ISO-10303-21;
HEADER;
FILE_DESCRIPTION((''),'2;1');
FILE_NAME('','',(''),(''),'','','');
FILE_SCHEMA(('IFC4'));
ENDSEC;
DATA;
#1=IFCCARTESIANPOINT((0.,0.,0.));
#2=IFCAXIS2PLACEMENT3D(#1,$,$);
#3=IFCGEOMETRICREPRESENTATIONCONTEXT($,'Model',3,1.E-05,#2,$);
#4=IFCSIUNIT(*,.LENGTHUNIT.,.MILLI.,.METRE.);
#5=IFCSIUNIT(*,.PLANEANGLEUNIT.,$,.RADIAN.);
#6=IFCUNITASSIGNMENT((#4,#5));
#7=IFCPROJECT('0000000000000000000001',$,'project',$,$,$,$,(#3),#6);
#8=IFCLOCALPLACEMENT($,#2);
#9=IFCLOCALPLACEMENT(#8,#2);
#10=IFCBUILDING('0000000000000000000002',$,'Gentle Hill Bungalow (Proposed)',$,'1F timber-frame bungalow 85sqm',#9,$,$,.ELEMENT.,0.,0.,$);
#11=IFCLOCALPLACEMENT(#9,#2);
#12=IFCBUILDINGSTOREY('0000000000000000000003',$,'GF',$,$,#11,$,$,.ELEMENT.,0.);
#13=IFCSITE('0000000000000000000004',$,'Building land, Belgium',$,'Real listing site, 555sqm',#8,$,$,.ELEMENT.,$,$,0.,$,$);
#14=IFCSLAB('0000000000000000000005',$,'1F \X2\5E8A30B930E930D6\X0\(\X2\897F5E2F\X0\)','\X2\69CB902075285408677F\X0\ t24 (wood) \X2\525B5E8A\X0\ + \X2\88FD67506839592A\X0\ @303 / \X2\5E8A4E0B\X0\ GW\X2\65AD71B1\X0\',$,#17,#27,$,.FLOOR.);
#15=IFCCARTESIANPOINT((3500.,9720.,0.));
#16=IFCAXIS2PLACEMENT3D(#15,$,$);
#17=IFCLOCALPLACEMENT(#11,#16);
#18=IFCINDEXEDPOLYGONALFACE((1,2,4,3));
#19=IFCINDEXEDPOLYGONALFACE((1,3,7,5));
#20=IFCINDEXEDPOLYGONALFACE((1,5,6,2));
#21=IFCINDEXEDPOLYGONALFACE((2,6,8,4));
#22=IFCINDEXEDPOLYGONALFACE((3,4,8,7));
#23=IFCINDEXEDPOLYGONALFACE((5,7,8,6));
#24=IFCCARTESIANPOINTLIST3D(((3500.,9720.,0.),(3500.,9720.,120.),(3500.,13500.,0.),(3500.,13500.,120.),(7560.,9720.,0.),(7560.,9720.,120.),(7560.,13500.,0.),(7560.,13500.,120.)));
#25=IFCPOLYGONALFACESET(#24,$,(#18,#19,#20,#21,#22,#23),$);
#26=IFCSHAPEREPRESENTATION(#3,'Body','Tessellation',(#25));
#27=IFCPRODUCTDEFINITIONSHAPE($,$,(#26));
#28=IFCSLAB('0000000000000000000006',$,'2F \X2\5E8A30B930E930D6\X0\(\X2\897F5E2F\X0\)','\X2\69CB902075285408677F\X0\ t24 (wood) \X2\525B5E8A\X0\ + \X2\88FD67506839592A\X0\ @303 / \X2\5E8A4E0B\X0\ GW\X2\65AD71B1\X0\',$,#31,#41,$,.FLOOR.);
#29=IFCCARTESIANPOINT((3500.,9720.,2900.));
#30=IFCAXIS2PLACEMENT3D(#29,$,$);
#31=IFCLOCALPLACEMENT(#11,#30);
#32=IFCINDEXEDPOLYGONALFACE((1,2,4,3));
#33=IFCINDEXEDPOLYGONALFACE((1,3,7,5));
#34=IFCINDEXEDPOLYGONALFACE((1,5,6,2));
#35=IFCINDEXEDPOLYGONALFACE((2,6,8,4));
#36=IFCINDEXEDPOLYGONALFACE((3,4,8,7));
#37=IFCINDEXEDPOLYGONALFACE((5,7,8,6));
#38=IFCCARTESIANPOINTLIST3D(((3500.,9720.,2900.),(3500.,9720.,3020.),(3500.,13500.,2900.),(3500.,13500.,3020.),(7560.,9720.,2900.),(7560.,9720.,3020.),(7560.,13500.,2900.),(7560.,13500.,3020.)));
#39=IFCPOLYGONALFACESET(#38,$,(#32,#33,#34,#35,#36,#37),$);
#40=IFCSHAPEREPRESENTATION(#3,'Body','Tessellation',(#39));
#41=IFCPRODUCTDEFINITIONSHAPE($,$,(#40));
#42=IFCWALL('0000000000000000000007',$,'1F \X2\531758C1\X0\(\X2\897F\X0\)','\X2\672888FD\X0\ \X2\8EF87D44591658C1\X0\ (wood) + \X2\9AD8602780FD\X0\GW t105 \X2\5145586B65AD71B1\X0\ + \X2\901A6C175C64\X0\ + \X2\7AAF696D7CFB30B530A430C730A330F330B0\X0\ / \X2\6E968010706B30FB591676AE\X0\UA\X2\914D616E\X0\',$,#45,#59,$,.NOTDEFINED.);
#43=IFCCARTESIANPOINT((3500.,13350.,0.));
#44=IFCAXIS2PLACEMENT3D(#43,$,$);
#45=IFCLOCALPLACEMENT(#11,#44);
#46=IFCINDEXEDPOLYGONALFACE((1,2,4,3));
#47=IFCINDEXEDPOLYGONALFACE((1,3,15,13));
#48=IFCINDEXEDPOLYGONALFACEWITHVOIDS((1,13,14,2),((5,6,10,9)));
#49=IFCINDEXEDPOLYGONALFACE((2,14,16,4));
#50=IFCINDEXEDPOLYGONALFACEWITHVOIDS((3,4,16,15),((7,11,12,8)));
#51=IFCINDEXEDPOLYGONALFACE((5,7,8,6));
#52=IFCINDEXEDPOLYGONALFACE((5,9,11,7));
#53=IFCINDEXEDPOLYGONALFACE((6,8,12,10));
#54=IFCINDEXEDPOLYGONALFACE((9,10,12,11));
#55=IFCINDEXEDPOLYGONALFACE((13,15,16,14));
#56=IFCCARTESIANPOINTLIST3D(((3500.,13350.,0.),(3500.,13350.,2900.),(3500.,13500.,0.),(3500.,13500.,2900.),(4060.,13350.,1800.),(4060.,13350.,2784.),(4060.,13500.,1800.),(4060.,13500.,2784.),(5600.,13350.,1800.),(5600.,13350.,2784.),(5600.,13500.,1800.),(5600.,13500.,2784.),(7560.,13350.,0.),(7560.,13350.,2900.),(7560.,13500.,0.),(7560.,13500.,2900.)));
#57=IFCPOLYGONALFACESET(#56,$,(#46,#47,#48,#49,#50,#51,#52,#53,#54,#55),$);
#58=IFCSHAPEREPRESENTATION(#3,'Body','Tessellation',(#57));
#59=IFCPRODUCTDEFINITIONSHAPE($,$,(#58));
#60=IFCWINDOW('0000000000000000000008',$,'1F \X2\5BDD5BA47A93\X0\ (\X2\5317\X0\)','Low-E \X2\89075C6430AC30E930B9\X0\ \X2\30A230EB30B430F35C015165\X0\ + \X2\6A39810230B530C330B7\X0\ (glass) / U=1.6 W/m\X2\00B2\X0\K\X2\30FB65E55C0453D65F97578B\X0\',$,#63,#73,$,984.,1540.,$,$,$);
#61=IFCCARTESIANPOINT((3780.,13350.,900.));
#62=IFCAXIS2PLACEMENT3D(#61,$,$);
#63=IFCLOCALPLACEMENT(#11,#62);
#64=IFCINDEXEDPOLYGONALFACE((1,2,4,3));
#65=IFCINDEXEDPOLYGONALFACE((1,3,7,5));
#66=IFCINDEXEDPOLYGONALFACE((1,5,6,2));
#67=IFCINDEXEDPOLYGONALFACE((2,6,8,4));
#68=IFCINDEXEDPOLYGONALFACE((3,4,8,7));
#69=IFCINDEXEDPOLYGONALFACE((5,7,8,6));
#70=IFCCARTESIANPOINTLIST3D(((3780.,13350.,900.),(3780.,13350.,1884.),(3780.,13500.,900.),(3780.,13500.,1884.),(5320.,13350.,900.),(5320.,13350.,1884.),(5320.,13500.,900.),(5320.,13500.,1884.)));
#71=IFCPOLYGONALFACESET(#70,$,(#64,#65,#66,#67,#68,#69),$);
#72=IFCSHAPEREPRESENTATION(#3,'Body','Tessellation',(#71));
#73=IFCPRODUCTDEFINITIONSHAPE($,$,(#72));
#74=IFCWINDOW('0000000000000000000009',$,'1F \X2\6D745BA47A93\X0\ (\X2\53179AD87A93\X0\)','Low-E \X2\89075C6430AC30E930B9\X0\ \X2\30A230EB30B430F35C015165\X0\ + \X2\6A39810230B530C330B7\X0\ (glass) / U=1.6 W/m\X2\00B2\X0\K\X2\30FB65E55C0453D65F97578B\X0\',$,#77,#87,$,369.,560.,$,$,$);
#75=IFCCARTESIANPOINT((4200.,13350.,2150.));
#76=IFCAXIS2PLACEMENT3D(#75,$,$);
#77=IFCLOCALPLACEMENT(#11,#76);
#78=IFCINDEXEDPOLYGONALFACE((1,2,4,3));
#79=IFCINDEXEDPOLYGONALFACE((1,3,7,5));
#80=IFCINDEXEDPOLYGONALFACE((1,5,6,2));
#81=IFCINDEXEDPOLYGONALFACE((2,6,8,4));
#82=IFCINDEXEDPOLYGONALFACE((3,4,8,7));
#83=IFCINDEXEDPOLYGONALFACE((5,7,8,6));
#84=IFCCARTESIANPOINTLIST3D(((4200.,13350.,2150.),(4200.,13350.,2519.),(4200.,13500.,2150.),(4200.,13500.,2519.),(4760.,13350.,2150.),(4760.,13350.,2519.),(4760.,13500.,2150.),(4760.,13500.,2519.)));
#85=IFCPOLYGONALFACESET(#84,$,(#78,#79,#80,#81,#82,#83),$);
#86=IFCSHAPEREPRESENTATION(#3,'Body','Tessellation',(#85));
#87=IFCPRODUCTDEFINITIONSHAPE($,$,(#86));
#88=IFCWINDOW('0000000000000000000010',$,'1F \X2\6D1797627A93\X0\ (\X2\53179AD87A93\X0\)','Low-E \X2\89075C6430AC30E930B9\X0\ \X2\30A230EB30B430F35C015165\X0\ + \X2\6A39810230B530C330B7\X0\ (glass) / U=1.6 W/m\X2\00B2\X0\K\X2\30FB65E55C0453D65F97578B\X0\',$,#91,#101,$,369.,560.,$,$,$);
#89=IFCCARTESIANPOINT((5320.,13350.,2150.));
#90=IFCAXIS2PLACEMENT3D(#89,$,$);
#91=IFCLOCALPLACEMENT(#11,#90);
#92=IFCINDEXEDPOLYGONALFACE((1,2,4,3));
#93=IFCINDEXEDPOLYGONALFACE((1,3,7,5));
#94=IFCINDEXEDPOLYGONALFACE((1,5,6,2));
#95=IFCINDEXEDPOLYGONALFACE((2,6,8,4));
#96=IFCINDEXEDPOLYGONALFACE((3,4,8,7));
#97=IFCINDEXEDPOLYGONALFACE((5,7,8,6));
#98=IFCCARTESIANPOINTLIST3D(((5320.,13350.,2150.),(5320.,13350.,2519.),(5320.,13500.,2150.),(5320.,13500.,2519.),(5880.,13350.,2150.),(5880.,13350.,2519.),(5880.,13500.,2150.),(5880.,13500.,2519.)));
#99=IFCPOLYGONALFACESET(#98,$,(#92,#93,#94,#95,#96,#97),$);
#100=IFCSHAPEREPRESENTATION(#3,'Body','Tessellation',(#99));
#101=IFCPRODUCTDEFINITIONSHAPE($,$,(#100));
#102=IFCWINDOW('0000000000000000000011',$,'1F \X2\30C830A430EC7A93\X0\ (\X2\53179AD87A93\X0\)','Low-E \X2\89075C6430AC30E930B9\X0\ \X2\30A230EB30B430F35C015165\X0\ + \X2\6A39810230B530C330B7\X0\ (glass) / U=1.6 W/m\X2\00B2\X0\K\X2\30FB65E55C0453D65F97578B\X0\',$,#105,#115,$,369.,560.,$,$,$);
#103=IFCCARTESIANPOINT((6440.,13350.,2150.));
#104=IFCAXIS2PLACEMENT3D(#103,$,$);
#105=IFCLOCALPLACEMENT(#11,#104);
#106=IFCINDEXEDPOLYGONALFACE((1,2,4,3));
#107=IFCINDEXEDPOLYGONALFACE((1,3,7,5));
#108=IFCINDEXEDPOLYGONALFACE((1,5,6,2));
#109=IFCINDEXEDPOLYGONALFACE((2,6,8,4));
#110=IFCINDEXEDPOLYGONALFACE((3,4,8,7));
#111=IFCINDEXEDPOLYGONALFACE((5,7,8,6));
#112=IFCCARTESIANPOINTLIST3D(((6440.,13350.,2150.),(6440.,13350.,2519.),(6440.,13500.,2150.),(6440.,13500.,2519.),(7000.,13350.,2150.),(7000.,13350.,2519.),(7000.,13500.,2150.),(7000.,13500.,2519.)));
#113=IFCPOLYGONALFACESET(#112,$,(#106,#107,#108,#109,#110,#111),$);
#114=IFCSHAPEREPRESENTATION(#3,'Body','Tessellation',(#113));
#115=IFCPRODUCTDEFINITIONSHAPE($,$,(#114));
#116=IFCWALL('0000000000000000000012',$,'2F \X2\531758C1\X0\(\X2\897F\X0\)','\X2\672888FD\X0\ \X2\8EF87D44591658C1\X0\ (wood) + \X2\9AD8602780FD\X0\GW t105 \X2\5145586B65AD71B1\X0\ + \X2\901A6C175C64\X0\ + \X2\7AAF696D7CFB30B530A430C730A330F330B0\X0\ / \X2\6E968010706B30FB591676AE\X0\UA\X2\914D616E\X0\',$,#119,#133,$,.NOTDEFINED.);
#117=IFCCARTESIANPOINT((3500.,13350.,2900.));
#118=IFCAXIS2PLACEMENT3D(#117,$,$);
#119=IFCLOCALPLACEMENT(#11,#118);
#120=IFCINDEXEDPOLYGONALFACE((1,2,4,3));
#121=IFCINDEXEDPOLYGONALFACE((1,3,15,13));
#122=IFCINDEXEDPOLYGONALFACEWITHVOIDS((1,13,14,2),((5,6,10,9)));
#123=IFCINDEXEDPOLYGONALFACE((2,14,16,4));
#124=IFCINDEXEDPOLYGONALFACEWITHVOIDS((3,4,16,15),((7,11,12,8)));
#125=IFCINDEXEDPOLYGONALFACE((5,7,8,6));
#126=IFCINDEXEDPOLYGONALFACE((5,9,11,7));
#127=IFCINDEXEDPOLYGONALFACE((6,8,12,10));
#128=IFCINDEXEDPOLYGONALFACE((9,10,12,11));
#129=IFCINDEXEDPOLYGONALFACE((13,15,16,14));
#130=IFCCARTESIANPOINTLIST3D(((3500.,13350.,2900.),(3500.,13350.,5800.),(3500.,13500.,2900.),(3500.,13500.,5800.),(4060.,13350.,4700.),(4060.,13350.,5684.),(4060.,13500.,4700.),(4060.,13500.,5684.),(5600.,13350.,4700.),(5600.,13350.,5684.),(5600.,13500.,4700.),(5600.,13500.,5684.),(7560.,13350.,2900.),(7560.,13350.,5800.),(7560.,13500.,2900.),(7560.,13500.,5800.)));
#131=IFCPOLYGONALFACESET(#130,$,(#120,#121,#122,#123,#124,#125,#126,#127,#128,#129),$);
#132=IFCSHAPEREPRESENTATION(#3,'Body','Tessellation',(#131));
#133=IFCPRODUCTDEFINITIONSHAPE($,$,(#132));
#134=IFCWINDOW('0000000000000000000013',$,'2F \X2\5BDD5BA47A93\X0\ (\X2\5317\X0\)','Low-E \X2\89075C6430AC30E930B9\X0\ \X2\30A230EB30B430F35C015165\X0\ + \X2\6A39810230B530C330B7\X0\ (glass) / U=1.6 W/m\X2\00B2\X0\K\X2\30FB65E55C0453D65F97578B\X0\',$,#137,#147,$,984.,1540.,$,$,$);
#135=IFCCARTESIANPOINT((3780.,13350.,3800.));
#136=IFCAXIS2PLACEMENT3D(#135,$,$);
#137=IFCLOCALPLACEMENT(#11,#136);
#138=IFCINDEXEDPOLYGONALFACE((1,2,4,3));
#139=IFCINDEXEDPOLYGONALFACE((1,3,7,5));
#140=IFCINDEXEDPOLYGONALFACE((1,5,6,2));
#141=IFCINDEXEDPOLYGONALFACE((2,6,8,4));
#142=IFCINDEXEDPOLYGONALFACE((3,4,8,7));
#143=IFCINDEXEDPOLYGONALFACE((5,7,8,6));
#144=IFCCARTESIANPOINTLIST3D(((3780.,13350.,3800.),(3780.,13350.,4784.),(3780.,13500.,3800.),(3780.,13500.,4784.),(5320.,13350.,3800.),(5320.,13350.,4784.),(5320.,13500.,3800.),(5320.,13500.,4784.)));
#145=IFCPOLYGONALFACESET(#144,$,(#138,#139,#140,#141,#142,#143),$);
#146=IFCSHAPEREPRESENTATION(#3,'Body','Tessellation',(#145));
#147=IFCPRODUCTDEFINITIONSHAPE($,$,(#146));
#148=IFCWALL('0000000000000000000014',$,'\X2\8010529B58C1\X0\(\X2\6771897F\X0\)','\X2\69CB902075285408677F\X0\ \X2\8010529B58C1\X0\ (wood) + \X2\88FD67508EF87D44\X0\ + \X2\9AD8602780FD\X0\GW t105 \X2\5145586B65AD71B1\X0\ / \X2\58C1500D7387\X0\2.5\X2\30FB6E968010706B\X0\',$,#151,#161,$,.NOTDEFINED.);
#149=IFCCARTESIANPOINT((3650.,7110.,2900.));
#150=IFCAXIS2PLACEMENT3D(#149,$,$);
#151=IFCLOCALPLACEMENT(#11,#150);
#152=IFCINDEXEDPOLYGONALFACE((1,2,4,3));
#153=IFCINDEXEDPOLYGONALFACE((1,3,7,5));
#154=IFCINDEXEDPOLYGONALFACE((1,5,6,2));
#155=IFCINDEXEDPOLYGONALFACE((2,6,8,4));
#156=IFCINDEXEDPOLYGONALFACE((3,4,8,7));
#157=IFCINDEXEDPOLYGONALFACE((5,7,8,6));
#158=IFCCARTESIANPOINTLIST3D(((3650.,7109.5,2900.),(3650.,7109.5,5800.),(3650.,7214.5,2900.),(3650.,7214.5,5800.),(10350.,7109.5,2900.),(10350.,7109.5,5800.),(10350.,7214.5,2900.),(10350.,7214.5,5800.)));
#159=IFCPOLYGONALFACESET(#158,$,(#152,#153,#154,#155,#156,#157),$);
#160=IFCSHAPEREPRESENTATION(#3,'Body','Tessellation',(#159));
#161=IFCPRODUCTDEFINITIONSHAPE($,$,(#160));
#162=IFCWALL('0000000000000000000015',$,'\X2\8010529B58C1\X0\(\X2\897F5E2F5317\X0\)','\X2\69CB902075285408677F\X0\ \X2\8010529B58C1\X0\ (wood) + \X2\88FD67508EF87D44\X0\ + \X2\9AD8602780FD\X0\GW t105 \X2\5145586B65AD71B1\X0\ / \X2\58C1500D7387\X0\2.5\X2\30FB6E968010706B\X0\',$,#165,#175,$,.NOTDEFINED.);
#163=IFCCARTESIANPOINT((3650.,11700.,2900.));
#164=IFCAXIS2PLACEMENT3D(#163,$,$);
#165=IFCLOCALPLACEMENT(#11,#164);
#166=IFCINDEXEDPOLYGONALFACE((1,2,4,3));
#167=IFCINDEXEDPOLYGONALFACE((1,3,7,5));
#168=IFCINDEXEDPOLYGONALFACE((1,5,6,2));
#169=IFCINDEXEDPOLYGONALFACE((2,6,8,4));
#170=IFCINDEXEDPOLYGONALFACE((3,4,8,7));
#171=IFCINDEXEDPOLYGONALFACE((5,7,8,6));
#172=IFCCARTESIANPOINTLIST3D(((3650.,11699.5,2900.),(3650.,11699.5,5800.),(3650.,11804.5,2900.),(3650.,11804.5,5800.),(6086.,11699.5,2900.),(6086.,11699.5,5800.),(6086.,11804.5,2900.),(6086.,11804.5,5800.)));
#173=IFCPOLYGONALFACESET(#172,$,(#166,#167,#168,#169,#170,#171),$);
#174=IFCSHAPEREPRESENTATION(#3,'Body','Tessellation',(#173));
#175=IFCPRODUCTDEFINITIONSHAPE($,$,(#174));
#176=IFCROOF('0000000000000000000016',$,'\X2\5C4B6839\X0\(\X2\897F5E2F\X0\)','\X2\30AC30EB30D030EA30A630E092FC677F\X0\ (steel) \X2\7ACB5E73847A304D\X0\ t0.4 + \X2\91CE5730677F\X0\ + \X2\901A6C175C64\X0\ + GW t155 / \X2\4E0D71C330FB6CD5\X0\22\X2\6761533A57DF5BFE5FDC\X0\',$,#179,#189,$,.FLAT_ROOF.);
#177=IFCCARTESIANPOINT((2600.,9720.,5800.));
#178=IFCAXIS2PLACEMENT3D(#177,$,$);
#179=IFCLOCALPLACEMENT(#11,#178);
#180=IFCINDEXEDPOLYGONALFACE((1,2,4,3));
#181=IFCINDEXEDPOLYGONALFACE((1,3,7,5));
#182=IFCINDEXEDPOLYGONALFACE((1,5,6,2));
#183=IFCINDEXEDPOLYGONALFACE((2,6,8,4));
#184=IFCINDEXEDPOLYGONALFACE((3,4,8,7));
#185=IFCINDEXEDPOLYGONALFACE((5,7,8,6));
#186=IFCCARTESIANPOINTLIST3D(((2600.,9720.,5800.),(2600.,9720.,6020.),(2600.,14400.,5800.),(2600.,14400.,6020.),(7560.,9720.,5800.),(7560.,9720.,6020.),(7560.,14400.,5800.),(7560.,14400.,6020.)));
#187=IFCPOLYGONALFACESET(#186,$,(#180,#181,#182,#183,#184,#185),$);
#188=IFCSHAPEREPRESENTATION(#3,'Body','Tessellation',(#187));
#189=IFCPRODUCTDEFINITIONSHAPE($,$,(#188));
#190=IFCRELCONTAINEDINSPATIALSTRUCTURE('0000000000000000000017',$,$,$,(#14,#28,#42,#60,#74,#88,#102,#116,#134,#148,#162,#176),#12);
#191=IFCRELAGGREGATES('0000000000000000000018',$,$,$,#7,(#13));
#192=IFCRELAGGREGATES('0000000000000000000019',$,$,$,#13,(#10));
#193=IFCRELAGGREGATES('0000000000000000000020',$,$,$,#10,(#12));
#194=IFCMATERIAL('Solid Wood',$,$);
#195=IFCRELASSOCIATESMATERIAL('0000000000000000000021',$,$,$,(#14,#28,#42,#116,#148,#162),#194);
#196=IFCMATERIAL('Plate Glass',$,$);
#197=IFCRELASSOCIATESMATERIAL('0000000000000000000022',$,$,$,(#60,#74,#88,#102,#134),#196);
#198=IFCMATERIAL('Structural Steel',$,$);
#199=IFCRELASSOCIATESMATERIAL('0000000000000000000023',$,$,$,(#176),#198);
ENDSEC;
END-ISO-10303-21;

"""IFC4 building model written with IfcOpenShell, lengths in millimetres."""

from ifc_helpers import new_model, si_unit, frame, frame_2d, origin, place, context, project, spatial, rectangle, extrude, material, element, fill, save


model = new_model("IFC4")

# Units and contexts
model_context = context("Model", 3, precision=1e-05, world=origin())
ifc_project = project(units=[si_unit("LENGTHUNIT", "METRE", prefix="MILLI"), si_unit("PLANEANGLEUNIT", "RADIAN")], contexts=[model_context])

# Site, building, storey
site_placement = place(None, origin())
site = spatial("IfcSite", under=ifc_project, at=site_placement, Name="Building land, Belgium", ObjectType="Real listing site, 555sqm", CompositionType="ELEMENT", RefElevation=0.0)
building_placement = place(site_placement, origin())
building = spatial("IfcBuilding", under=site, at=building_placement, Name="Gentle Hill Bungalow (Proposed)", ObjectType="1F timber-frame bungalow 85sqm", CompositionType="ELEMENT", ElevationOfRefHeight=0.0, ElevationOfTerrain=0.0)
storey_placement = place(building_placement, origin())
storey = spatial("IfcBuildingStorey", under=building, at=storey_placement, Name="GF", CompositionType="ELEMENT", Elevation=0.0)

# Slabs
ifc_material_1 = material(Name="Solid Wood")
slab_1_placement = place(storey_placement, frame((3500.0, 9720.0, 0.0)))
element("IfcSlab", 1, at=slab_1_placement, inside=storey, material=ifc_material_1, Name="1F 床スラブ(西帯)", Description="構造用合板 t24 (wood) 剛床 + 製材根太 @303 / 床下 GW断熱", PredefinedType="FLOOR", context=model_context, shape_type="SweptSolid", body=[
    extrude(rectangle(XDim=4060.0, YDim=3780.0, at=frame_2d((2030.0, 1890.0))), frame((3500.0, 9720.0, 0.0)), (0.0, 0.0, 1.0), 120.0),
])
slab_2_placement = place(storey_placement, frame((3500.0, 9720.0, 2900.0)))
element("IfcSlab", 2, at=slab_2_placement, inside=storey, material=ifc_material_1, Name="2F 床スラブ(西帯)", Description="構造用合板 t24 (wood) 剛床 + 製材根太 @303 / 床下 GW断熱", PredefinedType="FLOOR", context=model_context, shape_type="SweptSolid", body=[
    extrude(rectangle(XDim=4060.0, YDim=3780.0, at=frame_2d((2030.0, 1890.0))), frame((3500.0, 9720.0, 2900.0)), (0.0, 0.0, 1.0), 120.0),
])

# Wall, openings, windows
wall_1_placement = place(storey_placement, frame((3500.0, 13350.0, 0.0)))
wall_1 = element("IfcWall", 3, at=wall_1_placement, inside=storey, material=ifc_material_1, Name="1F 北壁(西)", Description="木製 軸組外壁 (wood) + 高性能GW t105 充填断熱 + 通気層 + 窯業系サイディング / 準耐火・外皮UA配慮", PredefinedType="NOTDEFINED", context=model_context, shape_type="SweptSolid", body=[
    extrude(rectangle(XDim=4060.0, YDim=150.0, at=frame_2d((2030.0, 75.0))), frame((3500.0, 13350.0, 0.0)), (0.0, 0.0, 1.0), 2900.0),
])
opening_1_placement = place(storey_placement, frame((3780.0, 13350.0, 900.0)))
opening_1 = element("IfcOpeningElement", 4, at=opening_1_placement, cuts=wall_1, PredefinedType="NOTDEFINED", context=model_context, shape_type="SweptSolid", body=[
    extrude(rectangle(XDim=1540.0, YDim=150.0, at=frame_2d((770.0, 75.0))), frame((3780.0, 13350.0, 900.0)), (0.0, 0.0, 1.0), 984.0),
])
opening_2_placement = place(storey_placement, frame((4200.0, 13350.0, 2150.0)))
opening_2 = element("IfcOpeningElement", 5, at=opening_2_placement, cuts=wall_1, PredefinedType="NOTDEFINED", context=model_context, shape_type="SweptSolid", body=[
    extrude(rectangle(XDim=560.0, YDim=150.0, at=frame_2d((280.0, 75.0))), frame((4200.0, 13350.0, 2150.0)), (0.0, 0.0, 1.0), 369.0),
])
opening_3_placement = place(storey_placement, frame((5320.0, 13350.0, 2150.0)))
opening_3 = element("IfcOpeningElement", 6, at=opening_3_placement, cuts=wall_1, PredefinedType="NOTDEFINED", context=model_context, shape_type="SweptSolid", body=[
    extrude(rectangle(XDim=560.0, YDim=150.0, at=frame_2d((280.0, 75.0))), frame((5320.0, 13350.0, 2150.0)), (0.0, 0.0, 1.0), 369.0),
])
opening_4_placement = place(storey_placement, frame((6440.0, 13350.0, 2150.0)))
opening_4 = element("IfcOpeningElement", 7, at=opening_4_placement, cuts=wall_1, PredefinedType="NOTDEFINED", context=model_context, shape_type="SweptSolid", body=[
    extrude(rectangle(XDim=560.0, YDim=150.0, at=frame_2d((280.0, 75.0))), frame((6440.0, 13350.0, 2150.0)), (0.0, 0.0, 1.0), 369.0),
])
ifc_material_2 = material(Name="Plate Glass")
window_1_placement = place(storey_placement, frame((3780.0, 13350.0, 900.0)))
window_1 = element("IfcWindow", 8, at=window_1_placement, inside=storey, material=ifc_material_2, Name="1F 寝室窓 (北)", Description="Low-E 複層ガラス アルゴン封入 + 樹脂サッシ (glass) / U=1.6 W/m²K・日射取得型", OverallHeight=984.0, OverallWidth=1540.0, context=model_context, shape_type="SweptSolid", body=[
    extrude(rectangle(XDim=1540.0, YDim=150.0, at=frame_2d((770.0, 75.0))), frame((3780.0, 13350.0, 900.0)), (0.0, 0.0, 1.0), 984.0),
])
fill(opening_1, window_1)
window_2_placement = place(storey_placement, frame((4200.0, 13350.0, 2150.0)))
window_2 = element("IfcWindow", 9, at=window_2_placement, inside=storey, material=ifc_material_2, Name="1F 浴室窓 (北高窓)", Description="Low-E 複層ガラス アルゴン封入 + 樹脂サッシ (glass) / U=1.6 W/m²K・日射取得型", OverallHeight=369.0, OverallWidth=560.0, context=model_context, shape_type="SweptSolid", body=[
    extrude(rectangle(XDim=560.0, YDim=150.0, at=frame_2d((280.0, 75.0))), frame((4200.0, 13350.0, 2150.0)), (0.0, 0.0, 1.0), 369.0),
])
fill(opening_2, window_2)
window_3_placement = place(storey_placement, frame((5320.0, 13350.0, 2150.0)))
window_3 = element("IfcWindow", 10, at=window_3_placement, inside=storey, material=ifc_material_2, Name="1F 洗面窓 (北高窓)", Description="Low-E 複層ガラス アルゴン封入 + 樹脂サッシ (glass) / U=1.6 W/m²K・日射取得型", OverallHeight=369.0, OverallWidth=560.0, context=model_context, shape_type="SweptSolid", body=[
    extrude(rectangle(XDim=560.0, YDim=150.0, at=frame_2d((280.0, 75.0))), frame((5320.0, 13350.0, 2150.0)), (0.0, 0.0, 1.0), 369.0),
])
fill(opening_3, window_3)
window_4_placement = place(storey_placement, frame((6440.0, 13350.0, 2150.0)))
window_4 = element("IfcWindow", 11, at=window_4_placement, inside=storey, material=ifc_material_2, Name="1F トイレ窓 (北高窓)", Description="Low-E 複層ガラス アルゴン封入 + 樹脂サッシ (glass) / U=1.6 W/m²K・日射取得型", OverallHeight=369.0, OverallWidth=560.0, context=model_context, shape_type="SweptSolid", body=[
    extrude(rectangle(XDim=560.0, YDim=150.0, at=frame_2d((280.0, 75.0))), frame((6440.0, 13350.0, 2150.0)), (0.0, 0.0, 1.0), 369.0),
])
fill(opening_4, window_4)

# Wall, opening, window
wall_2_placement = place(storey_placement, frame((3500.0, 13350.0, 2900.0)))
wall_2 = element("IfcWall", 12, at=wall_2_placement, inside=storey, material=ifc_material_1, Name="2F 北壁(西)", Description="木製 軸組外壁 (wood) + 高性能GW t105 充填断熱 + 通気層 + 窯業系サイディング / 準耐火・外皮UA配慮", PredefinedType="NOTDEFINED", context=model_context, shape_type="SweptSolid", body=[
    extrude(rectangle(XDim=4060.0, YDim=150.0, at=frame_2d((2030.0, 75.0))), frame((3500.0, 13350.0, 2900.0)), (0.0, 0.0, 1.0), 2900.0),
])
opening_5_placement = place(storey_placement, frame((3780.0, 13350.0, 3800.0)))
opening_5 = element("IfcOpeningElement", 13, at=opening_5_placement, cuts=wall_2, PredefinedType="NOTDEFINED", context=model_context, shape_type="SweptSolid", body=[
    extrude(rectangle(XDim=1540.0, YDim=150.0, at=frame_2d((770.0, 75.0))), frame((3780.0, 13350.0, 3800.0)), (0.0, 0.0, 1.0), 984.0),
])
window_5_placement = place(storey_placement, frame((3780.0, 13350.0, 3800.0)))
window_5 = element("IfcWindow", 14, at=window_5_placement, inside=storey, material=ifc_material_2, Name="2F 寝室窓 (北)", Description="Low-E 複層ガラス アルゴン封入 + 樹脂サッシ (glass) / U=1.6 W/m²K・日射取得型", OverallHeight=984.0, OverallWidth=1540.0, context=model_context, shape_type="SweptSolid", body=[
    extrude(rectangle(XDim=1540.0, YDim=150.0, at=frame_2d((770.0, 75.0))), frame((3780.0, 13350.0, 3800.0)), (0.0, 0.0, 1.0), 984.0),
])
fill(opening_5, window_5)

# Walls
wall_3_placement = place(storey_placement, frame((3650.0, 7110.0, 2900.0)))
element("IfcWall", 15, at=wall_3_placement, inside=storey, material=ifc_material_1, Name="耐力壁(東西)", Description="構造用合板 耐力壁 (wood) + 製材軸組 + 高性能GW t105 充填断熱 / 壁倍率2.5・準耐火", PredefinedType="NOTDEFINED", context=model_context, shape_type="SweptSolid", body=[
    extrude(rectangle(XDim=6700.0, YDim=105.0, at=frame_2d((3350.0, 52.0))), frame((3650.0, 7110.0, 2900.0)), (0.0, 0.0, 1.0), 2900.0),
])
wall_4_placement = place(storey_placement, frame((3650.0, 11700.0, 2900.0)))
element("IfcWall", 16, at=wall_4_placement, inside=storey, material=ifc_material_1, Name="耐力壁(西帯北)", Description="構造用合板 耐力壁 (wood) + 製材軸組 + 高性能GW t105 充填断熱 / 壁倍率2.5・準耐火", PredefinedType="NOTDEFINED", context=model_context, shape_type="SweptSolid", body=[
    extrude(rectangle(XDim=2436.0, YDim=105.0, at=frame_2d((1218.0, 52.0))), frame((3650.0, 11700.0, 2900.0)), (0.0, 0.0, 1.0), 2900.0),
])

# Roof
ifc_material_3 = material(Name="Structural Steel")
for number, where, name in (
    (17, (2600.0, 9720.0, 5800.0), "屋根(西帯)"),
):
    element("IfcRoof", number, at=place(storey_placement, frame(where)), inside=storey, material=ifc_material_3, Name=name, Description="ガルバリウム鋼板 (steel) 立平葺き t0.4 + 野地板 + 通気層 + GW t155 / 不燃・法22条区域対応", PredefinedType="FLAT_ROOF", context=model_context, shape_type="SweptSolid", body=[
        extrude(rectangle(XDim=4960.0, YDim=4680.0, at=frame_2d((2480.0, 2340.0))), frame((2600.0, 9720.0, 5800.0)), (0.0, 0.0, 1.0), 220.0),
    ])

save(model, "model.ifc")
